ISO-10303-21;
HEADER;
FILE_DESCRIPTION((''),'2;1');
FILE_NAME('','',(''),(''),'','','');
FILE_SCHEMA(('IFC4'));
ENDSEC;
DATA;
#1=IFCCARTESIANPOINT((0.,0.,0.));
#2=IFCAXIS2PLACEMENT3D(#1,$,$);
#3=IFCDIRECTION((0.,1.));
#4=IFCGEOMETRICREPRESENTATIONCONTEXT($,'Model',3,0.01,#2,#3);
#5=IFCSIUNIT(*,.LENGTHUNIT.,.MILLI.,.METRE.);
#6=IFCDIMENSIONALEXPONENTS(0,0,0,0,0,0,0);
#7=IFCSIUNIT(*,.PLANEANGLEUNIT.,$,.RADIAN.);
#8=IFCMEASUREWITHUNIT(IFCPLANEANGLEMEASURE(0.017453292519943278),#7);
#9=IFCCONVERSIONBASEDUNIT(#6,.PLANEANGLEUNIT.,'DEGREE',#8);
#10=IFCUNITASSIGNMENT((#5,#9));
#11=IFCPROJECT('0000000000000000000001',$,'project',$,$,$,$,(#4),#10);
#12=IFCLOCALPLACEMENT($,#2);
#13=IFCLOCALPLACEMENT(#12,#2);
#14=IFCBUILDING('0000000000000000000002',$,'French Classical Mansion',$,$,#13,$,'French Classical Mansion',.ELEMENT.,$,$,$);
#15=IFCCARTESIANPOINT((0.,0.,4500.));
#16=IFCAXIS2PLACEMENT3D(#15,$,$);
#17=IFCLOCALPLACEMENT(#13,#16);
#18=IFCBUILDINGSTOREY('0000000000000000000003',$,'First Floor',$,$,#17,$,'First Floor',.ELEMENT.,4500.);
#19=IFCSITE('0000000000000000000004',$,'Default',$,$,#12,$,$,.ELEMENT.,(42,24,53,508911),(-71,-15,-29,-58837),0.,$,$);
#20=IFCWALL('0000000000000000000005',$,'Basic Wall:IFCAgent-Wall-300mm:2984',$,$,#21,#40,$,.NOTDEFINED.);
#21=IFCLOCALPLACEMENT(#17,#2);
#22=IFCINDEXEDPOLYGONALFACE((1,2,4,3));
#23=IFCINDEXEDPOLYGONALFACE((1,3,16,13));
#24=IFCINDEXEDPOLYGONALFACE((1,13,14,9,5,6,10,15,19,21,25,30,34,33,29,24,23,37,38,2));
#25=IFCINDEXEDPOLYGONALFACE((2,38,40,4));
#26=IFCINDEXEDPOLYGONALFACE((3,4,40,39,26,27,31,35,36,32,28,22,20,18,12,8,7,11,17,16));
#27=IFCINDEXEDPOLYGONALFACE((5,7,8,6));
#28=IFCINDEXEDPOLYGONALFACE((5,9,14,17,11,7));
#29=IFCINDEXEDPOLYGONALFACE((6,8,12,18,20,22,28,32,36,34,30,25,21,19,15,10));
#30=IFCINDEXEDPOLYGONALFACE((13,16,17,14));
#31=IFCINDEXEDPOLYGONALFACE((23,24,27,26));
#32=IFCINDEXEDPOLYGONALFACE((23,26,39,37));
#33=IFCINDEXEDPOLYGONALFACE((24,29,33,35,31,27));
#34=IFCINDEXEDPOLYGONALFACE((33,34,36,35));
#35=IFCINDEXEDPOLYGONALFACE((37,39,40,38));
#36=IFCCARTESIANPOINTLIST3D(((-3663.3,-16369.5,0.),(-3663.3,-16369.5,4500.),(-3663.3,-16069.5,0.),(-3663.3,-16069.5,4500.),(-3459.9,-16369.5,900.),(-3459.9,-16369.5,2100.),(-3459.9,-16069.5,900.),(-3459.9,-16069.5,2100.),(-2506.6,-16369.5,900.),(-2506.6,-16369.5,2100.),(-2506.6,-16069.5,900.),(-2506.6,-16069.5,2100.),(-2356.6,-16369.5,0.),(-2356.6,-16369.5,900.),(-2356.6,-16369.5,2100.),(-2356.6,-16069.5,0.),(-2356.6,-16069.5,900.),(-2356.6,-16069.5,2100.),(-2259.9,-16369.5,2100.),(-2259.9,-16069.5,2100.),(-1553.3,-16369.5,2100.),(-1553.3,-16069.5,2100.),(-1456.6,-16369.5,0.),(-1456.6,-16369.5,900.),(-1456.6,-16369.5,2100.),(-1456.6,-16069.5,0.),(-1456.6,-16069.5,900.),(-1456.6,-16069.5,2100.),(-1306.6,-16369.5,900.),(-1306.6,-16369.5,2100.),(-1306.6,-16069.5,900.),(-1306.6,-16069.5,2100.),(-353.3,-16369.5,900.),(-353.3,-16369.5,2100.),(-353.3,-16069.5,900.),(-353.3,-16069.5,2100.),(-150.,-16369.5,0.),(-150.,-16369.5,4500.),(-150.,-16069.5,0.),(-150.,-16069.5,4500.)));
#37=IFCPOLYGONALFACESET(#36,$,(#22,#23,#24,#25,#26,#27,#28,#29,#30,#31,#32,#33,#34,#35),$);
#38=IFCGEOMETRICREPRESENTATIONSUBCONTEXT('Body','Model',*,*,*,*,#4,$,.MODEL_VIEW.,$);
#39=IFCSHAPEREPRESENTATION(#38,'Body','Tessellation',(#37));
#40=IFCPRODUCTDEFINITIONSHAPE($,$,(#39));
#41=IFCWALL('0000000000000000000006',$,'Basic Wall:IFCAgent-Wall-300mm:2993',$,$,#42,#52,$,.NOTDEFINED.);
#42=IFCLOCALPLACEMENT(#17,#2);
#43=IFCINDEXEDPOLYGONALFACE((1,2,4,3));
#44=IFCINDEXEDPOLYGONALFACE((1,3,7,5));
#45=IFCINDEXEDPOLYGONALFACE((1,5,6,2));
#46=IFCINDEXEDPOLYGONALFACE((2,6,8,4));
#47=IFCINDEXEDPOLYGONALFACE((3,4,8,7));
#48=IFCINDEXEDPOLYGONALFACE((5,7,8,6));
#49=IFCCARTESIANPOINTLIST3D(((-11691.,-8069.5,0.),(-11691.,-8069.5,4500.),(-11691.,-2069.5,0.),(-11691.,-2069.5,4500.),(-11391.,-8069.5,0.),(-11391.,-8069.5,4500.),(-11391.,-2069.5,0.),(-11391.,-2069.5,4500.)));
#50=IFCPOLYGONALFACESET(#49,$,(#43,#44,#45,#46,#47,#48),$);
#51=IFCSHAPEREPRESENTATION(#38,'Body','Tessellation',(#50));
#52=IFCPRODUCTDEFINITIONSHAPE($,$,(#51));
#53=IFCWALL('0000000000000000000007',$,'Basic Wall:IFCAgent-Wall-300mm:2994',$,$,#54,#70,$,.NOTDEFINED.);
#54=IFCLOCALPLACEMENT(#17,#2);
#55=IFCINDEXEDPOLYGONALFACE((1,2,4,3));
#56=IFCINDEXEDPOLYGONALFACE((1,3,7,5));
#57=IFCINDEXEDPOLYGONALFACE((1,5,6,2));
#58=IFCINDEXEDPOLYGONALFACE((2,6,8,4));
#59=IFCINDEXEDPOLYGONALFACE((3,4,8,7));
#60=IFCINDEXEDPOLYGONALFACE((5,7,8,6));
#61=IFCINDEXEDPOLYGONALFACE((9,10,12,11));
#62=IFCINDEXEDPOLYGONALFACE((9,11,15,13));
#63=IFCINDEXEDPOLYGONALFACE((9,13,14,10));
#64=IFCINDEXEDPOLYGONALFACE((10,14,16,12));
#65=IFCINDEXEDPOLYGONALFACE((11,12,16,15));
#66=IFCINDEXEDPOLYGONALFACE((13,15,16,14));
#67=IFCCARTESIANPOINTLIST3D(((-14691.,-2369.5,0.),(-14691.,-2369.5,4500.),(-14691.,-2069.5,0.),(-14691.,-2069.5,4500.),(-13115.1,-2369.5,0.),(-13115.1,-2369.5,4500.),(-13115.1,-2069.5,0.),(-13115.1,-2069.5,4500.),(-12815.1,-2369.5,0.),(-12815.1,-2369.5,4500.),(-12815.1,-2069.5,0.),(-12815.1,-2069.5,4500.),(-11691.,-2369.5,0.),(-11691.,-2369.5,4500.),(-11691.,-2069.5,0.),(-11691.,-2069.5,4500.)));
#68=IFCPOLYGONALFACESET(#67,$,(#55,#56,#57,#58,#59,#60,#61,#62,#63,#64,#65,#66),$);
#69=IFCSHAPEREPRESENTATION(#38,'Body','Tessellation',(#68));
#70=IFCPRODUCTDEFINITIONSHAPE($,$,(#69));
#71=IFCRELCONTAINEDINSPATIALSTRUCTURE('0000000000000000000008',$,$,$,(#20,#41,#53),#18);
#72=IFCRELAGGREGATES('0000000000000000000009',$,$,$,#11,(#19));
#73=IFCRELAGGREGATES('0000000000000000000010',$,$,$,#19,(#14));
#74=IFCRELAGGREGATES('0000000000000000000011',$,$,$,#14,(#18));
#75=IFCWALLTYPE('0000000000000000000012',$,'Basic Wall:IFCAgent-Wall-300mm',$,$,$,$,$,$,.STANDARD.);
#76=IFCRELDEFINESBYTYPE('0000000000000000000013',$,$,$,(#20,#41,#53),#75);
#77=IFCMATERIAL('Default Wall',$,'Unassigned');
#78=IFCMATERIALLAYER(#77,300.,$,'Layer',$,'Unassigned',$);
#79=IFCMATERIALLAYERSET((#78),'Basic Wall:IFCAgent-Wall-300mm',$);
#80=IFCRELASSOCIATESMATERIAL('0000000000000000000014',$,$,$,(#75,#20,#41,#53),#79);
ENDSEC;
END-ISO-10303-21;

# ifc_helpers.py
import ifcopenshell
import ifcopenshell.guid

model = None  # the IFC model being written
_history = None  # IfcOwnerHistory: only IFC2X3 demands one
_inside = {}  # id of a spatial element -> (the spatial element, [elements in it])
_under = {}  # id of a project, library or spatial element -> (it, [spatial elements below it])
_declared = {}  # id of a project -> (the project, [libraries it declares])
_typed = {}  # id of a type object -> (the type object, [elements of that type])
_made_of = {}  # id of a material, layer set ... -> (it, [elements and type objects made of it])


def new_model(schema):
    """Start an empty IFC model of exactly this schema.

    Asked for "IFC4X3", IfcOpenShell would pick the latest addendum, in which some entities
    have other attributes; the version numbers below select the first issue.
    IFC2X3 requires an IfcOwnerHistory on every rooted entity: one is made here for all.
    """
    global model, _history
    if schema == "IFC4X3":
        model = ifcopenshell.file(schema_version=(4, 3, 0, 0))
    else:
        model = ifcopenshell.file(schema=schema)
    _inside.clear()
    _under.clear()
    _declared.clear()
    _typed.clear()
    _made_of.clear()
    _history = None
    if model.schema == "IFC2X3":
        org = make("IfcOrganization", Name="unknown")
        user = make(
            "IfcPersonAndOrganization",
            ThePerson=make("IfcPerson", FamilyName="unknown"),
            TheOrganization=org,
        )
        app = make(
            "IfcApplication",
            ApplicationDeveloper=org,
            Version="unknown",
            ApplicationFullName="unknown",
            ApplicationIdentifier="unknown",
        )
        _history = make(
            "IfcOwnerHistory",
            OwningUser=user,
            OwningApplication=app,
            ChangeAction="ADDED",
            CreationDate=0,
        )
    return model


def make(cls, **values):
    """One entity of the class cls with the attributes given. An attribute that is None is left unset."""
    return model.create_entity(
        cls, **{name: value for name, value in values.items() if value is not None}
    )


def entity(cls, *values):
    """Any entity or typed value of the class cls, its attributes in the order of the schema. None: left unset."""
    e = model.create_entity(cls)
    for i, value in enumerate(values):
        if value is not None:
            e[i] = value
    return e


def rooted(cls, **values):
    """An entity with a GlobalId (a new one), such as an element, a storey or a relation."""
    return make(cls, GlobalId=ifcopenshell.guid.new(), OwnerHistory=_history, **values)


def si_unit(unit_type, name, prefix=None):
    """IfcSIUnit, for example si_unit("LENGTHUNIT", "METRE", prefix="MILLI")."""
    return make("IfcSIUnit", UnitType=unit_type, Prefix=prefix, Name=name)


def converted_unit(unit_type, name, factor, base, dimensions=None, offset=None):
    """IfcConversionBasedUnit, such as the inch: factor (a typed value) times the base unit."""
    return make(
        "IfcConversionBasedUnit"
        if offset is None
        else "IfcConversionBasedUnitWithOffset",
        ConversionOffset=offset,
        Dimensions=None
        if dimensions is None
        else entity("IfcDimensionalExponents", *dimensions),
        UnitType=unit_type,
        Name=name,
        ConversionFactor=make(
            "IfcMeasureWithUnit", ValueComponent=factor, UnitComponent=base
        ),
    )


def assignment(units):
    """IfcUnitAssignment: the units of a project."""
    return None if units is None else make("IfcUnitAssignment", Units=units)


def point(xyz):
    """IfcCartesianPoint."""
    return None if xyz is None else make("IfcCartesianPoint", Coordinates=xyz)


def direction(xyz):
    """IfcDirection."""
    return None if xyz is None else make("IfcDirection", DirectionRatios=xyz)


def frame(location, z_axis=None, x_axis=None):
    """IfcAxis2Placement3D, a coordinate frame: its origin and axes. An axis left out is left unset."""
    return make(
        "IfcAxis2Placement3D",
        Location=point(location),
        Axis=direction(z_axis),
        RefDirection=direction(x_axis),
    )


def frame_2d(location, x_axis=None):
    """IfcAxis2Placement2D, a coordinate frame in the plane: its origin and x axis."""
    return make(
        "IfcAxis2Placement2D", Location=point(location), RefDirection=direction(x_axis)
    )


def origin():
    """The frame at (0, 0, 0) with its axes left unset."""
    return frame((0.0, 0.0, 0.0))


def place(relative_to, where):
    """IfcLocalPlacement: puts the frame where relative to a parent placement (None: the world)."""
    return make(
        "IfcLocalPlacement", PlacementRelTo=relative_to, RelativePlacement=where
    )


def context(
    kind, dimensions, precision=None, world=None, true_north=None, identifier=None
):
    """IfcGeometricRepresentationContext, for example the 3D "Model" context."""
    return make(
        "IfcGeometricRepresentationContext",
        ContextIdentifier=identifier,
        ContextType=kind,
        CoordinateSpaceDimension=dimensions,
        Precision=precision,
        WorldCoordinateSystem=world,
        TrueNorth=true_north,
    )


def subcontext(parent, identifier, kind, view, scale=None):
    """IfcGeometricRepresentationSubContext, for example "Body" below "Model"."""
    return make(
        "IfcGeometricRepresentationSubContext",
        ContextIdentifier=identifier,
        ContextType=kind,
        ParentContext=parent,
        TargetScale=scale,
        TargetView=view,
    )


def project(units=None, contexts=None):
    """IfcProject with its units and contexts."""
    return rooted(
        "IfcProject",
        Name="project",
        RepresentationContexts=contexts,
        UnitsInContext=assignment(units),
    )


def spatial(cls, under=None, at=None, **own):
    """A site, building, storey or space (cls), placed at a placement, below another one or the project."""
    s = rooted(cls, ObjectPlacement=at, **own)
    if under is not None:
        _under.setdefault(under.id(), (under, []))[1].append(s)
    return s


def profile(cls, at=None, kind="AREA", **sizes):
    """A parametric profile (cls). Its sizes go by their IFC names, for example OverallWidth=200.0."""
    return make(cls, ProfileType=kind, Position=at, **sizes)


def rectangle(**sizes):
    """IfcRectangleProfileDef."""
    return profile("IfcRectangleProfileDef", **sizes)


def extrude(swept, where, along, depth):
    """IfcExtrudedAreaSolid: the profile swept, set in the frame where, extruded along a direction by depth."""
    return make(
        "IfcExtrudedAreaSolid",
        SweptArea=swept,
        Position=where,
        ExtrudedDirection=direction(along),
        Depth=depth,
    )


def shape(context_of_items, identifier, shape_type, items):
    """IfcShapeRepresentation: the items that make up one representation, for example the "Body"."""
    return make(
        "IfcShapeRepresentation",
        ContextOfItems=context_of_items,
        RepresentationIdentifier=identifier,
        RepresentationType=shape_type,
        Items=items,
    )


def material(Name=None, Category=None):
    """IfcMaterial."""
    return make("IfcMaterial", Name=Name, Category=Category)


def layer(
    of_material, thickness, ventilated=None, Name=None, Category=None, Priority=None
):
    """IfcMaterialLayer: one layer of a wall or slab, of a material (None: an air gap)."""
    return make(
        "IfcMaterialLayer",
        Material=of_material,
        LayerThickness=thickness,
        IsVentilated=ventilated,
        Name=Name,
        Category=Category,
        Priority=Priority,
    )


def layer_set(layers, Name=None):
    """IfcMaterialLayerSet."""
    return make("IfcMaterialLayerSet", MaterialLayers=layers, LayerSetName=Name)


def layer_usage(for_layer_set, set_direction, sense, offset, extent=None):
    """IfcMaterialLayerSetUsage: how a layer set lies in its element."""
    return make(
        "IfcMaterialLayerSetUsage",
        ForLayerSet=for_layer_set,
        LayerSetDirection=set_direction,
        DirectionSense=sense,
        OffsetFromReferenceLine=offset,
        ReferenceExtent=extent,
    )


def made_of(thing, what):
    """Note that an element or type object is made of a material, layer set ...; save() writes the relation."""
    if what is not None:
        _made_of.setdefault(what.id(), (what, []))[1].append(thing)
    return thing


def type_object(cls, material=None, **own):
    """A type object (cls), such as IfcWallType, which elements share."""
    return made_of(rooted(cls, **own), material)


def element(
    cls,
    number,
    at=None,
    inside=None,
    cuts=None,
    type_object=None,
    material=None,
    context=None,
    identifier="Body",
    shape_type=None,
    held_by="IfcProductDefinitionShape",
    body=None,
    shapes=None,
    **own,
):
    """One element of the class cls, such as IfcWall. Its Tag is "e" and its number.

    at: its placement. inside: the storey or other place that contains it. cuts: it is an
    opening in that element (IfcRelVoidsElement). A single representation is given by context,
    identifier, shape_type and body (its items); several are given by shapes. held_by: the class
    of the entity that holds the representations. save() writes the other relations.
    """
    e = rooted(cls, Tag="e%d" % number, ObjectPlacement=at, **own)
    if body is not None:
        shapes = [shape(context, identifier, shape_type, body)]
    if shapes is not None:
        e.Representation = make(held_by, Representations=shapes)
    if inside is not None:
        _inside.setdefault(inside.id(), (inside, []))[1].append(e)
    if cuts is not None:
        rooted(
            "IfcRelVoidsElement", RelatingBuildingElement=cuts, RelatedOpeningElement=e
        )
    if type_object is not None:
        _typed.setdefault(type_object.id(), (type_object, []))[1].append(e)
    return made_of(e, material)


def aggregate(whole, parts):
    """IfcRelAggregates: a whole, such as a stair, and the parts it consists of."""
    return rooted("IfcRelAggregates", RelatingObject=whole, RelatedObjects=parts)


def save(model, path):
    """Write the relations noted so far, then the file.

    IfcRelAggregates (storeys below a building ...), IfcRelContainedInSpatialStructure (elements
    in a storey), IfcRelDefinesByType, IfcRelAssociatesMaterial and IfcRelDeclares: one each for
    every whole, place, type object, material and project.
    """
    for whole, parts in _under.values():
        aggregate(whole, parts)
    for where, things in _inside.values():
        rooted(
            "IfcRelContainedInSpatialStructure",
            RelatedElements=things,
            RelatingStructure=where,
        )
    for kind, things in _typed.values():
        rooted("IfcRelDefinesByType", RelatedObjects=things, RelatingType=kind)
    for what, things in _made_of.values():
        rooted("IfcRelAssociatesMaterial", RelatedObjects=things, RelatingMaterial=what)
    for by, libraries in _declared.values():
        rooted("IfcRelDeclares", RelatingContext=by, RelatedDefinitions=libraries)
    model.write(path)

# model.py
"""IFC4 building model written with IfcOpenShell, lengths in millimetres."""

from ifc_helpers import new_model, entity, si_unit, converted_unit, direction, frame, frame_2d, origin, place, context, subcontext, project, spatial, rectangle, extrude, material, layer, layer_set, layer_usage, type_object, element, save


model = new_model("IFC4")

# Units and contexts
model_context = context("Model", 3, precision=0.01, world=origin(), true_north=direction((0.0, 1.0)))
body_context = subcontext(model_context, "Body", "Model", "MODEL_VIEW")
ifc_project = project(units=[si_unit("LENGTHUNIT", "METRE", prefix="MILLI"), converted_unit("PLANEANGLEUNIT", "DEGREE", entity("IfcPlaneAngleMeasure", 0.017453292519943278), si_unit("PLANEANGLEUNIT", "RADIAN"), dimensions=[0, 0, 0, 0, 0, 0, 0])], contexts=[model_context])

# Site, building, storey
site_placement = place(None, origin())
site = spatial("IfcSite", under=ifc_project, at=site_placement, Name="Default", CompositionType="ELEMENT", RefLatitude=(42, 24, 53, 508911), RefLongitude=(-71, -15, -29, -58837), RefElevation=0.0)
building_placement = place(site_placement, origin())
building = spatial("IfcBuilding", under=site, at=building_placement, Name="French Classical Mansion", LongName="French Classical Mansion", CompositionType="ELEMENT")
storey_placement = place(building_placement, frame((0.0, 0.0, 4500.0)))
storey = spatial("IfcBuildingStorey", under=building, at=storey_placement, Name="First Floor", LongName="First Floor", CompositionType="ELEMENT", Elevation=4500.0)

# Shared definitions
ifc_material = material(Name="Default Wall", Category="Unassigned")
ifc_layer = layer(ifc_material, 300.0, Name="Layer", Category="Unassigned")
ifc_layer_set = layer_set([ifc_layer], Name="Basic Wall:IFCAgent-Wall-300mm")
wall_type = type_object("IfcWallType", Name="Basic Wall:IFCAgent-Wall-300mm", PredefinedType="STANDARD", material=ifc_layer_set)

# Wall, openings
ifc_layer_usage_1 = layer_usage(ifc_layer_set, "AXIS2", "NEGATIVE", 150.0)
wall_1_placement = place(storey_placement, frame((-3663.3, -16219.5, 0.0)))
wall_1 = element("IfcWall", 1, at=wall_1_placement, inside=storey, type_object=wall_type, material=ifc_layer_usage_1, Name="Basic Wall:IFCAgent-Wall-300mm:2984", PredefinedType="NOTDEFINED", context=body_context, shape_type="SweptSolid", body=[
    extrude(rectangle(XDim=3513.3, YDim=300.0, at=frame_2d((1756.6, 0.0), x_axis=(-1.0, 0.0))), origin(), (0.0, 0.0, 1.0), 4500.0),
])
opening_1_placement = place(wall_1_placement, origin())
element("IfcOpeningElement", 2, at=opening_1_placement, cuts=wall_1, PredefinedType="OPENING", context=body_context, shape_type="SweptSolid", body=[
    extrude(rectangle(XDim=2100.0, YDim=900.0, at=frame_2d((0.0, 0.0), x_axis=(1.0, 0.0))), frame((1756.6, -150.0, 1050.0), z_axis=(0.0, 1.0, 0.0), x_axis=(0.0, 0.0, -1.0)), (0.0, 0.0, 1.0), 300.0),
])
opening_2_placement = place(wall_1_placement, origin())
element("IfcOpeningElement", 3, at=opening_2_placement, cuts=wall_1, PredefinedType="OPENING", context=body_context, shape_type="SweptSolid", body=[
    extrude(rectangle(XDim=1200.0, YDim=1200.0, at=frame_2d((0.0, 0.0), x_axis=(1.0, 0.0))), frame((803.3, -150.0, 1500.0), z_axis=(0.0, 1.0, 0.0), x_axis=(0.0, 0.0, -1.0)), (0.0, 0.0, 1.0), 300.0),
])
opening_3_placement = place(wall_1_placement, origin())
element("IfcOpeningElement", 4, at=opening_3_placement, cuts=wall_1, PredefinedType="OPENING", context=body_context, shape_type="SweptSolid", body=[
    extrude(rectangle(XDim=1200.0, YDim=1200.0, at=frame_2d((0.0, 0.0), x_axis=(1.0, 0.0))), frame((1756.6, -150.0, 1500.0), z_axis=(0.0, 1.0, 0.0), x_axis=(0.0, 0.0, -1.0)), (0.0, 0.0, 1.0), 300.0),
])
opening_4_placement = place(wall_1_placement, origin())
element("IfcOpeningElement", 5, at=opening_4_placement, cuts=wall_1, PredefinedType="OPENING", context=body_context, shape_type="SweptSolid", body=[
    extrude(rectangle(XDim=1200.0, YDim=1200.0, at=frame_2d((0.0, 0.0), x_axis=(1.0, 0.0))), frame((2709.9, -150.0, 1500.0), z_axis=(0.0, 1.0, 0.0), x_axis=(0.0, 0.0, -1.0)), (0.0, 0.0, 1.0), 300.0),
])

# Wall
ifc_layer_usage_2 = layer_usage(ifc_layer_set, "AXIS2", "NEGATIVE", 150.0)
wall_2_placement = place(storey_placement, frame((-11541.0, -8069.5, 0.0), z_axis=(0.0, 0.0, 1.0), x_axis=(0.0, 1.0, 0.0)))
element("IfcWall", 6, at=wall_2_placement, inside=storey, type_object=wall_type, material=ifc_layer_usage_2, Name="Basic Wall:IFCAgent-Wall-300mm:2993", PredefinedType="NOTDEFINED", context=body_context, shape_type="SweptSolid", body=[
    extrude(rectangle(XDim=6000.0, YDim=300.0, at=frame_2d((3000.0, 0.0), x_axis=(-1.0, 0.0))), origin(), (0.0, 0.0, 1.0), 4500.0),
])

# Wall, opening
ifc_layer_usage_3 = layer_usage(ifc_layer_set, "AXIS2", "NEGATIVE", 150.0)
wall_3_placement = place(storey_placement, frame((-11691.0, -2219.5, 0.0), z_axis=(0.0, 0.0, 1.0), x_axis=(-1.0, 0.0, 0.0)))
wall_3 = element("IfcWall", 7, at=wall_3_placement, inside=storey, type_object=wall_type, material=ifc_layer_usage_3, Name="Basic Wall:IFCAgent-Wall-300mm:2994", PredefinedType="NOTDEFINED", context=body_context, shape_type="SweptSolid", body=[
    extrude(rectangle(XDim=3000.0, YDim=300.0, at=frame_2d((1500.0, 0.0), x_axis=(-1.0, 0.0))), origin(), (0.0, 0.0, 1.0), 4500.0),
])
opening_5_placement = place(storey_placement, frame((-11691.0, -2219.5, 0.0), z_axis=(0.0, 0.0, 1.0), x_axis=(-1.0, 0.0, 0.0)))
element("IfcOpeningElement", 8, at=opening_5_placement, cuts=wall_3, PredefinedType="OPENING", context=body_context, shape_type="SweptSolid", body=[
    extrude(rectangle(XDim=4500.0, YDim=300.0, at=frame_2d((0.0, 0.0), x_axis=(1.0, 0.0))), frame((1424.1, 0.0, 2250.0), z_axis=(-1.0, 0.0, 0.0), x_axis=(0.0, 0.0, 1.0)), (0.0, 0.0, 1.0), 300.0),
])

save(model, "model.ifc")
